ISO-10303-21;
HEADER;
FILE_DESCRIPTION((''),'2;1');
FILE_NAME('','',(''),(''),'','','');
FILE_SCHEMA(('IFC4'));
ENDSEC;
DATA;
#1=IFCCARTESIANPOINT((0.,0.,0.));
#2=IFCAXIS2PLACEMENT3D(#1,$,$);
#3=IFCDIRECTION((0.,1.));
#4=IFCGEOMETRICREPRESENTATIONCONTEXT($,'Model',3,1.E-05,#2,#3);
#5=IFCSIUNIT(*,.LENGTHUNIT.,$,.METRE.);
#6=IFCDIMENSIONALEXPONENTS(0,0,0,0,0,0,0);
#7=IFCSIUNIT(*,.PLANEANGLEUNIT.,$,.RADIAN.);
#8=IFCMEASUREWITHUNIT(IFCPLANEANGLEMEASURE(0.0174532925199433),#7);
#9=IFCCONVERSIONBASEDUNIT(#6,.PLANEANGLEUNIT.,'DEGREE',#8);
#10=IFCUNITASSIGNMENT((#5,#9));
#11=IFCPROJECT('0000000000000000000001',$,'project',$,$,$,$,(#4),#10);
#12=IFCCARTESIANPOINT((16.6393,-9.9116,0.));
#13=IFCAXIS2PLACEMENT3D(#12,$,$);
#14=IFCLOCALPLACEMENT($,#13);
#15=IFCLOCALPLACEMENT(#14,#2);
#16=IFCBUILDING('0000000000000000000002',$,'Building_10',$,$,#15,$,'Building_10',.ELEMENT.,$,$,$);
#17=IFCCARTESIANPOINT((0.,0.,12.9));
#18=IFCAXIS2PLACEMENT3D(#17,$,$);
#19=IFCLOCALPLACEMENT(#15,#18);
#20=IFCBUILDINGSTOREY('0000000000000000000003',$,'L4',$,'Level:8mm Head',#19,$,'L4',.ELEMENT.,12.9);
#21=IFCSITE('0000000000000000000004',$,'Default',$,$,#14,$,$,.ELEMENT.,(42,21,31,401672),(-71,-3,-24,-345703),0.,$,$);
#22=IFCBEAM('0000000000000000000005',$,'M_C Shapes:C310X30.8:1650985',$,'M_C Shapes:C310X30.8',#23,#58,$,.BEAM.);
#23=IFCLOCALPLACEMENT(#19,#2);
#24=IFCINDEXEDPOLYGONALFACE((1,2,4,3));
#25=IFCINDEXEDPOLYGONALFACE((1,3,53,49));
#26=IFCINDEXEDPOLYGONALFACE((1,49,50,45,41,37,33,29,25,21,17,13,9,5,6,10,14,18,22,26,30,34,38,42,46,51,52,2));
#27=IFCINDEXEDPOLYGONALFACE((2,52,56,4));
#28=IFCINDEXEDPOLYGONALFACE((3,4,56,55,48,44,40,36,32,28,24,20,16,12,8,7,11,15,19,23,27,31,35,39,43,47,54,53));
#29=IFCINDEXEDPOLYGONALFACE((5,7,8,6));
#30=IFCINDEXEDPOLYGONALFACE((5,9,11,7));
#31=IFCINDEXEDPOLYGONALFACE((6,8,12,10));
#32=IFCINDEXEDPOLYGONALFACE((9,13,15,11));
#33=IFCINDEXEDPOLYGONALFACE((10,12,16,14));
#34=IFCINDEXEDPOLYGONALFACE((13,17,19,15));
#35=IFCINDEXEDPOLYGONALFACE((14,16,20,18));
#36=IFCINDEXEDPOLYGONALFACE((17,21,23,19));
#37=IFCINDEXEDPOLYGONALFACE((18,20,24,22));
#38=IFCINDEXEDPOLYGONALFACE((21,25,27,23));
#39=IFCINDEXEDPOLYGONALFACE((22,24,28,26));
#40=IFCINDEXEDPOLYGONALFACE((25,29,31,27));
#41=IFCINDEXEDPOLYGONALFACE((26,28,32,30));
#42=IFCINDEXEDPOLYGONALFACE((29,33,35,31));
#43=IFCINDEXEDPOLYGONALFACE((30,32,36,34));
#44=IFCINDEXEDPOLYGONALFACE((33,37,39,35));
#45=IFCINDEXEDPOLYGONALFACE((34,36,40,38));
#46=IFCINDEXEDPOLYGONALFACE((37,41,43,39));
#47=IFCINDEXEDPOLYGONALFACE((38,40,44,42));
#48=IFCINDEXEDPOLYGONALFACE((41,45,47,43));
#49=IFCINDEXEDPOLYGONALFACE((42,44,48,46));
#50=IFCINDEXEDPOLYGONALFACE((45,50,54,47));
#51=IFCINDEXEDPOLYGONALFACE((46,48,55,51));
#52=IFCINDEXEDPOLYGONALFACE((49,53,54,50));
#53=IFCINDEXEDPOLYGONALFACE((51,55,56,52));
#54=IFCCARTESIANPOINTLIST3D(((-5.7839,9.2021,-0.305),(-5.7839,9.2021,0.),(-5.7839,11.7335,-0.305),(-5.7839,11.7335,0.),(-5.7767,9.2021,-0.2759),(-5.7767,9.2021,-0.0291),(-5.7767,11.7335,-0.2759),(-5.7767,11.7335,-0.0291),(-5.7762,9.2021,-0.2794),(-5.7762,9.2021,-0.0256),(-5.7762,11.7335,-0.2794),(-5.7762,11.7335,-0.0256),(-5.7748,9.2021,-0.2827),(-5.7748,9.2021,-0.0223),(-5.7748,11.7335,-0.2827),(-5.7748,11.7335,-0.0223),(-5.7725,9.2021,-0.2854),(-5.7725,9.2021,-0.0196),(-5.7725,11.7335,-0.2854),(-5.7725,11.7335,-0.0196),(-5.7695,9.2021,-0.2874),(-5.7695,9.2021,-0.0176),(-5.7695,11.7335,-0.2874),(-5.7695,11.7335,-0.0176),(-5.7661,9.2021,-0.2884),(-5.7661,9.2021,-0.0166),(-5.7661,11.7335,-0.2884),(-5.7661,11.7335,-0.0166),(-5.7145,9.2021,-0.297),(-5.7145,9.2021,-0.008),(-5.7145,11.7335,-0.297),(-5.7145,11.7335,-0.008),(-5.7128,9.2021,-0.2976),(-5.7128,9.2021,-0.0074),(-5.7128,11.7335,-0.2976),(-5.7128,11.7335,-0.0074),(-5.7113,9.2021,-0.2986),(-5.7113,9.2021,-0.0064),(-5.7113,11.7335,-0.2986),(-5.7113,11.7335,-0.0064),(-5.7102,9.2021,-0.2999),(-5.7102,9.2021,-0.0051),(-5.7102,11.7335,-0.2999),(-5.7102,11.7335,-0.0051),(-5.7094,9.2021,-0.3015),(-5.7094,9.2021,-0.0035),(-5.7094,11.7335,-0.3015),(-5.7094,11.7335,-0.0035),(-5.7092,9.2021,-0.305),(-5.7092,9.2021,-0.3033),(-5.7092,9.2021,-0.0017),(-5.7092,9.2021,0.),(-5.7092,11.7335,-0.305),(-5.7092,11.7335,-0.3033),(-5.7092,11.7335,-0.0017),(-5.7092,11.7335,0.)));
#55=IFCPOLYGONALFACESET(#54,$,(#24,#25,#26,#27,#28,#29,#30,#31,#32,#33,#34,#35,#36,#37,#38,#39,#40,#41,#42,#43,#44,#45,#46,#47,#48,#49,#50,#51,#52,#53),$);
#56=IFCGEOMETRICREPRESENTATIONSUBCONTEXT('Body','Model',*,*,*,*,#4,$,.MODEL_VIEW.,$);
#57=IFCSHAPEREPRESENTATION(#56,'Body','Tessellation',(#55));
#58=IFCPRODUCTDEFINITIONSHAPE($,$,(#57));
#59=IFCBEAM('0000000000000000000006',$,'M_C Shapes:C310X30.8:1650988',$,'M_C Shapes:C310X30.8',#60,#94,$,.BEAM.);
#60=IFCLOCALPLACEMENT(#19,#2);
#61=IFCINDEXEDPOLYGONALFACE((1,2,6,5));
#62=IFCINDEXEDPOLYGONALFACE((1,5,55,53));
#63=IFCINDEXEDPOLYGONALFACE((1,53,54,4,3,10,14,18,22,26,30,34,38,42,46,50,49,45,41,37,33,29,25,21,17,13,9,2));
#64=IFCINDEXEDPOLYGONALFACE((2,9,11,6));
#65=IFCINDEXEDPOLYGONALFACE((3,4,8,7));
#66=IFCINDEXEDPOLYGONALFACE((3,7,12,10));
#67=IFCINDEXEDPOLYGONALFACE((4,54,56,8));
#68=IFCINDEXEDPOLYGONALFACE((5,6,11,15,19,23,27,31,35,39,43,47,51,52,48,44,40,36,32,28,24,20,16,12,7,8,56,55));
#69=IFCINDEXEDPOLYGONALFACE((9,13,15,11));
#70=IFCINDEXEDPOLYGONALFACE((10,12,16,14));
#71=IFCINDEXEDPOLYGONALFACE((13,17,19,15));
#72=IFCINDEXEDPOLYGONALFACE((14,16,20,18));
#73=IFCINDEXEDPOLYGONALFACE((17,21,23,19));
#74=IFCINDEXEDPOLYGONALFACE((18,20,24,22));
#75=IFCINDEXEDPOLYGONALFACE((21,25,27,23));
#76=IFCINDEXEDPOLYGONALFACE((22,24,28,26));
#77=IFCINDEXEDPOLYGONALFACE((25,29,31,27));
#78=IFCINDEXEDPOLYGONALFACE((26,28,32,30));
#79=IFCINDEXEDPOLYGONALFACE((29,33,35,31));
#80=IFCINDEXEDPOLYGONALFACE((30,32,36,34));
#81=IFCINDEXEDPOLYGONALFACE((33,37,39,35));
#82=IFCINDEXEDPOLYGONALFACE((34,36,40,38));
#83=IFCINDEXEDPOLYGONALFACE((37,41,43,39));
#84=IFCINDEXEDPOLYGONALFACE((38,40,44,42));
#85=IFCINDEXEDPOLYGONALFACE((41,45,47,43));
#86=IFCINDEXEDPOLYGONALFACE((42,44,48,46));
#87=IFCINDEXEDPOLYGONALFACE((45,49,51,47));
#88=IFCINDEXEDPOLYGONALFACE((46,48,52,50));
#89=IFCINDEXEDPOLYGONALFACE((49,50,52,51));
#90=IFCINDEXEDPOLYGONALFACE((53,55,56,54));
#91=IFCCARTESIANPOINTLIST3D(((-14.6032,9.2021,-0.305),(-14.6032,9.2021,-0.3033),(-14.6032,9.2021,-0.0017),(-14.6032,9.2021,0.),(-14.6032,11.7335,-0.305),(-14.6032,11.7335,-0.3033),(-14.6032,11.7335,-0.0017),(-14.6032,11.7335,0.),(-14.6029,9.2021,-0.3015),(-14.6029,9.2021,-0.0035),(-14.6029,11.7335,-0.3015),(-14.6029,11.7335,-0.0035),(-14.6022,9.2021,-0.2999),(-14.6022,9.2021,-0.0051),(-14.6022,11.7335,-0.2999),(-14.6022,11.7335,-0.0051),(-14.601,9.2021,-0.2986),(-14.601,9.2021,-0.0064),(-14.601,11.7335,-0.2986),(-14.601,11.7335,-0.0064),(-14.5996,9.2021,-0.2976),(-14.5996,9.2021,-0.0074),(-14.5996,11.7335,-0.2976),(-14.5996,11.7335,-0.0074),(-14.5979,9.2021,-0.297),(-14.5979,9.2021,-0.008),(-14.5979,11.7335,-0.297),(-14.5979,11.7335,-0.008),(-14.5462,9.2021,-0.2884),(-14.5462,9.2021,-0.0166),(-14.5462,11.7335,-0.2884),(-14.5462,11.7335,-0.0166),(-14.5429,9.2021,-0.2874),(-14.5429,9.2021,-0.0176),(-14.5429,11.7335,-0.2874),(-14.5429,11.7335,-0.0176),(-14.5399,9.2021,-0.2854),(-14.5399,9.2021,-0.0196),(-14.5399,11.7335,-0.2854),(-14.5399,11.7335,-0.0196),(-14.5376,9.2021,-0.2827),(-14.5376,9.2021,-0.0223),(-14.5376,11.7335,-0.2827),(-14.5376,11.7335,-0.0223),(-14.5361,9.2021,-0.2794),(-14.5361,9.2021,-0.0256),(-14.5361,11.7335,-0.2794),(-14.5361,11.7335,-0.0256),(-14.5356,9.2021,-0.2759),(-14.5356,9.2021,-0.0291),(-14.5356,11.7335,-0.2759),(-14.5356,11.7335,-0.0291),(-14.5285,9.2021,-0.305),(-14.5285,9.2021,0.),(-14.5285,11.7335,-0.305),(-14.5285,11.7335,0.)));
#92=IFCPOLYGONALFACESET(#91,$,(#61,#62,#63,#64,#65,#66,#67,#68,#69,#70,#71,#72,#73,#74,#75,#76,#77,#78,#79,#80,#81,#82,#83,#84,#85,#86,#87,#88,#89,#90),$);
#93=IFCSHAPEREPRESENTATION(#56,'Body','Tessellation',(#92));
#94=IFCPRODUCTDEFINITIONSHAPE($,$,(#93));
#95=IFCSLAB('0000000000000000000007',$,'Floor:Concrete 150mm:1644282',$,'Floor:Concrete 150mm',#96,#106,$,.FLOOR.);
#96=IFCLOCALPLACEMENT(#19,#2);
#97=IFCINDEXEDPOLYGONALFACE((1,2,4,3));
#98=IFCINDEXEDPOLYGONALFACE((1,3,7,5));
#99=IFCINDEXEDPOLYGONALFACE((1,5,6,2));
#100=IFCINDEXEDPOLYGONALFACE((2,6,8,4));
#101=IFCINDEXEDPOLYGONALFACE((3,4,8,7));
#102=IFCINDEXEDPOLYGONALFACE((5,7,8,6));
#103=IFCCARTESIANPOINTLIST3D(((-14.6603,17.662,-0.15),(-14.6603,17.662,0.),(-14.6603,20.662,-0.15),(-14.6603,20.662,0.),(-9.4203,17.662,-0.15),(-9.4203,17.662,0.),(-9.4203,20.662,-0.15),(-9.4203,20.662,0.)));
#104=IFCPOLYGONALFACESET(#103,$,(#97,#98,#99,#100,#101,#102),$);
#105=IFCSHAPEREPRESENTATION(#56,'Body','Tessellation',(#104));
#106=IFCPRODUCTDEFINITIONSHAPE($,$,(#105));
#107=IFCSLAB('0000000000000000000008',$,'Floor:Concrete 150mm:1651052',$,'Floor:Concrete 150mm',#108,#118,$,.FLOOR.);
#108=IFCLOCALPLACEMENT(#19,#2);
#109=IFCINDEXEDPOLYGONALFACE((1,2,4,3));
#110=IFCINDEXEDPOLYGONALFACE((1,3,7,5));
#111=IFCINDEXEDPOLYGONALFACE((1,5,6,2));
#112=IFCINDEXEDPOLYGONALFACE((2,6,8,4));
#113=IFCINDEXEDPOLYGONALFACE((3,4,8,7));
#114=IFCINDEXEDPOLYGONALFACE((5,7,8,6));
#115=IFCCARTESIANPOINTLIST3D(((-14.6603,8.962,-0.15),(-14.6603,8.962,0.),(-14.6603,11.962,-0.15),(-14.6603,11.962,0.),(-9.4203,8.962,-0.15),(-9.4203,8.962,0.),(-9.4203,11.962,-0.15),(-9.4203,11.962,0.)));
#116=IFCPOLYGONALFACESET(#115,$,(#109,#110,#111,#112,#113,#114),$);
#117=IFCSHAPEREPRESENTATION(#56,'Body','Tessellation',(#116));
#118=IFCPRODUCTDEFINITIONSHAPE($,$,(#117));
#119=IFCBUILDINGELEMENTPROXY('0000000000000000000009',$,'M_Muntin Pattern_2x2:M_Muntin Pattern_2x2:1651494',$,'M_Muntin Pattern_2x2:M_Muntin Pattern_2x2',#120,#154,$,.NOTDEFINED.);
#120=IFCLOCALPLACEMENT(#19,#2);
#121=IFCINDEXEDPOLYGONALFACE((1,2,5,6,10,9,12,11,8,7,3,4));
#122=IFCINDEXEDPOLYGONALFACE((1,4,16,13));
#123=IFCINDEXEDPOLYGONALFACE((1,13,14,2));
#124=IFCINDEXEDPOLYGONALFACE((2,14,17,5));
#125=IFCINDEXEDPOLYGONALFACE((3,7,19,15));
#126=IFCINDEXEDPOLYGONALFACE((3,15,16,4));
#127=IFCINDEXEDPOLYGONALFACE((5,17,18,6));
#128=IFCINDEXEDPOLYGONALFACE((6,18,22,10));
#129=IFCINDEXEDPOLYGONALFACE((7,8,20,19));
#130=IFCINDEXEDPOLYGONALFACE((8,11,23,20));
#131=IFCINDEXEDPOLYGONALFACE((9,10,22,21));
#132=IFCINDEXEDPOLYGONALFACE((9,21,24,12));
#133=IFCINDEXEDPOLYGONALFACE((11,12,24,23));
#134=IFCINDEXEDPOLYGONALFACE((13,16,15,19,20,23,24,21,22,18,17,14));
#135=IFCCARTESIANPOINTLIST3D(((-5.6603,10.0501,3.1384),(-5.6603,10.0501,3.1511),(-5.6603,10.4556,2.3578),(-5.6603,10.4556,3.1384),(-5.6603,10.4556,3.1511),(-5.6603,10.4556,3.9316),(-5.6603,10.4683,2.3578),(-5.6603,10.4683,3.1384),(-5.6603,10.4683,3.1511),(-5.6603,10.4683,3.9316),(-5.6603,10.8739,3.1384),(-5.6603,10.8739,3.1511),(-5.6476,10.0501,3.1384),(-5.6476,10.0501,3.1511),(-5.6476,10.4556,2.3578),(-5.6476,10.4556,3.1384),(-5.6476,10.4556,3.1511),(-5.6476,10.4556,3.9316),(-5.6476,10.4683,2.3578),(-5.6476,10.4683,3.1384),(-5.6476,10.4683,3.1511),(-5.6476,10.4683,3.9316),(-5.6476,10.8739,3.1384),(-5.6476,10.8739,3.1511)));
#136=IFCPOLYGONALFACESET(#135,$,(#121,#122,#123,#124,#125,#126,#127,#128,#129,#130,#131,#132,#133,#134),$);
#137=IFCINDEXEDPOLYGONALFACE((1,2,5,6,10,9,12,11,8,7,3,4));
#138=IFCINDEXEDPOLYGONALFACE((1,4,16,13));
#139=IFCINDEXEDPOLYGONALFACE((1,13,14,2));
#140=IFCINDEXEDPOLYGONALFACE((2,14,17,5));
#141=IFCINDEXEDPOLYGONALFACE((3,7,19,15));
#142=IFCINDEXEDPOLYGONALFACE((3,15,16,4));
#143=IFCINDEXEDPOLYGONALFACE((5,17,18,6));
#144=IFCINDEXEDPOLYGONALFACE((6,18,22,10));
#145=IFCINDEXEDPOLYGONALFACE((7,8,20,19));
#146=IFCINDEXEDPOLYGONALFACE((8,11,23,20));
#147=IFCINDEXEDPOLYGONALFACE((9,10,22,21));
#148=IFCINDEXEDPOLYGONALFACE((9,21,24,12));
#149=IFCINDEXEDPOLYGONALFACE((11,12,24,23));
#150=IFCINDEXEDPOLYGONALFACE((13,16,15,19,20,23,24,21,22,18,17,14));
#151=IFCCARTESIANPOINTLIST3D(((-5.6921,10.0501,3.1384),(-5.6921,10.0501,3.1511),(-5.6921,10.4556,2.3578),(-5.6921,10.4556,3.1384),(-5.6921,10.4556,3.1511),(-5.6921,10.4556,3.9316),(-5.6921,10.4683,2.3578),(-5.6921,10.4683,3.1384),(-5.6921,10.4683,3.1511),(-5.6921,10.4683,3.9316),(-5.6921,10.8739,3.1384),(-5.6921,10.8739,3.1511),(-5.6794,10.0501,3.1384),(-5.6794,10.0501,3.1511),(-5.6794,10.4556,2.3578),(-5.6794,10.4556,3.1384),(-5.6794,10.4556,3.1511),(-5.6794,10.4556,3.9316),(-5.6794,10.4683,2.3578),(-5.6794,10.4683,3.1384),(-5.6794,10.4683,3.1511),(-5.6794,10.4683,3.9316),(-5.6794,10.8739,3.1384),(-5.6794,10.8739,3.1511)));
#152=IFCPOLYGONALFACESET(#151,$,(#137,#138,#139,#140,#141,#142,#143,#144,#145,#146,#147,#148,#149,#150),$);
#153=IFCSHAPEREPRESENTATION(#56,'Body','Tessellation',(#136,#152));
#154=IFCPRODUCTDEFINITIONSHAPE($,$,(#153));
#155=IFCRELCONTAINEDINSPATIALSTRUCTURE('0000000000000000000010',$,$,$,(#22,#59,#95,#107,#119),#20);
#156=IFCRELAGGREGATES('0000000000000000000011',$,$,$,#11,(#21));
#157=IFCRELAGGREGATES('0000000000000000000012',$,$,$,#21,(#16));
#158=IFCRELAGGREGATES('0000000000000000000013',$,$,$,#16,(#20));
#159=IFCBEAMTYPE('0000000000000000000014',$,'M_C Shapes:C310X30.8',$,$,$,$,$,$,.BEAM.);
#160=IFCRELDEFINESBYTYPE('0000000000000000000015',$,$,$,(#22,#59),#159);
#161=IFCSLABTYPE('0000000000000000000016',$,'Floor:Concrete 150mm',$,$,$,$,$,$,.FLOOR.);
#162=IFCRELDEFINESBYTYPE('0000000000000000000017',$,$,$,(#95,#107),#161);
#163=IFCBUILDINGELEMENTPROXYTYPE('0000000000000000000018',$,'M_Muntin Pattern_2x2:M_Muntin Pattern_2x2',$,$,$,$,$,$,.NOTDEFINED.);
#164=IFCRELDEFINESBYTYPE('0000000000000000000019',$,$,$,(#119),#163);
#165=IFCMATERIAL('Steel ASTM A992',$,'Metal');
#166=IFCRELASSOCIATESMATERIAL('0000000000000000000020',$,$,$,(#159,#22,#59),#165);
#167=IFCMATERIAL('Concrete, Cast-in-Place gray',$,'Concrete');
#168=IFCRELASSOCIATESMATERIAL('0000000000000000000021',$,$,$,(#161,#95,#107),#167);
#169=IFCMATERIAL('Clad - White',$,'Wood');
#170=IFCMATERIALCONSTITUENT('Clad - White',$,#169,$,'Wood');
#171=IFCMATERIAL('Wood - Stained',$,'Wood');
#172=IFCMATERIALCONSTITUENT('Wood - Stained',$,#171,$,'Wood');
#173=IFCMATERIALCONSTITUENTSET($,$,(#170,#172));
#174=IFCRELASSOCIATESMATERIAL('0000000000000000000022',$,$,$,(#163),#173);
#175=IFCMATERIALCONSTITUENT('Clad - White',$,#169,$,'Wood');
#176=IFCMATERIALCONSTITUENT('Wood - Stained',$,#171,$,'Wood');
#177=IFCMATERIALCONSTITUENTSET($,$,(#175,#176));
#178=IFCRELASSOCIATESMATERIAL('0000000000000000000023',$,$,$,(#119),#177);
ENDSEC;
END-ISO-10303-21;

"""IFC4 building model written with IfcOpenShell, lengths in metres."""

from ifc_helpers import new_model, entity, si_unit, converted_unit, direction, frame, origin, place, context, subcontext, project, spatial, line, arc, indexed_curve, outline, extrude, source, transform, mapped, material, constituent, constituent_set, type_object, type_shapes, element, save


model = new_model("IFC4")

# Units and contexts
model_context = context("Model", 3, precision=1e-05, world=origin(), true_north=direction((0.0, 1.0)))
body_context = subcontext(model_context, "Body", "Model", "MODEL_VIEW")
ifc_project = project(units=[si_unit("LENGTHUNIT", "METRE"), converted_unit("PLANEANGLEUNIT", "DEGREE", entity("IfcPlaneAngleMeasure", 0.0174532925199433), si_unit("PLANEANGLEUNIT", "RADIAN"), dimensions=[0, 0, 0, 0, 0, 0, 0])], contexts=[model_context])

# Site, building, storey
site_placement = place(None, frame((16.6393, -9.9116, 0.0)))
site = spatial("IfcSite", under=ifc_project, at=site_placement, Name="Default", CompositionType="ELEMENT", RefLatitude=(42, 21, 31, 401672), RefLongitude=(-71, -3, -24, -345703), RefElevation=0.0)
building_placement = place(site_placement, origin())
building = spatial("IfcBuilding", under=site, at=building_placement, Name="Building_10", LongName="Building_10", CompositionType="ELEMENT")
storey_placement = place(building_placement, frame((0.0, 0.0, 12.9)))
storey = spatial("IfcBuildingStorey", under=building, at=storey_placement, Name="L4", ObjectType="Level:8mm Head", LongName="L4", CompositionType="ELEMENT", Elevation=12.9)

# Shared definitions
ifc_material_1 = material(Name="Steel ASTM A992", Category="Metal")

# Beams
beam_type_1 = type_object("IfcBeamType", Name="M_C Shapes:C310X30.8", PredefinedType="BEAM", material=ifc_material_1)
shared_shape_1 = source(origin(), body_context, "Body", "SweptSolid", [
    extrude(outline(indexed_curve([(-0.0406, -0.1525), (0.0341, -0.1525), (0.0341, -0.1508), (0.0326, -0.1467), (0.0288, -0.1445), (-0.0228, -0.1359), (-0.0305, -0.1316), (-0.0335, -0.1234), (-0.0335, 0.1234), (-0.0305, 0.1316), (-0.0228, 0.1359), (0.0288, 0.1445), (0.0326, 0.1467), (0.0341, 0.1508), (0.0341, 0.1525), (-0.0406, 0.1525)], segments=[line(1, 2, 3), arc(3, 4, 5), line(5, 6), arc(6, 7, 8), line(8, 9), arc(9, 10, 11), line(11, 12), arc(12, 13, 14), line(14, 15, 16, 1)], self_intersect=False)), frame((-1.2657, -0.0229, 0.0), z_axis=(1.0, 0.0, 0.0), x_axis=(0.0, -1.0, 0.0)), (0.0, 0.0, 1.0), 2.5314),
])
type_shapes(beam_type_1, [shared_shape_1])
for number, where, z_axis, x_axis, name in (
    (1, (-5.7662, 10.4678, -0.1525), (0.0, 0.0, 1.0), (0.0, 1.0, 0.0), "M_C Shapes:C310X30.8:1650985"),
    (2, (-14.5462, 10.4678, -0.1525), (0.0, 0.0, 1.0), (0.0, -1.0, 0.0), "M_C Shapes:C310X30.8:1650988"),
):
    element("IfcBeam", number, at=place(storey_placement, frame(where, z_axis=z_axis, x_axis=x_axis)), inside=storey, type_object=beam_type_1, material=ifc_material_1, Name=name, ObjectType="M_C Shapes:C310X30.8", PredefinedType="BEAM", context=body_context, shape_type="MappedRepresentation", body=[
        mapped(shared_shape_1, transform((0.0, 0.0, 0.0), scale=1.0)),
    ])

# Slabs
ifc_material_2 = material(Name="Concrete, Cast-in-Place gray", Category="Concrete")
slab_type = type_object("IfcSlabType", Name="Floor:Concrete 150mm", PredefinedType="FLOOR", material=ifc_material_2)
slab_1_placement = place(storey_placement, origin())
element("IfcSlab", 3, at=slab_1_placement, inside=storey, type_object=slab_type, material=ifc_material_2, Name="Floor:Concrete 150mm:1644282", ObjectType="Floor:Concrete 150mm", PredefinedType="FLOOR", context=body_context, shape_type="SweptSolid", body=[
    extrude(outline(indexed_curve([(-1.5, -2.62), (1.5, -2.62), (1.5, 2.62), (-1.5, 2.62), (-1.5, -2.62)], self_intersect=False)), frame((-12.0403, 19.162, 0.0), z_axis=(0.0, 0.0, -1.0), x_axis=(0.0, 1.0, 0.0)), (0.0, 0.0, 1.0), 0.15),
])
slab_2_placement = place(storey_placement, origin())
element("IfcSlab", 4, at=slab_2_placement, inside=storey, type_object=slab_type, material=ifc_material_2, Name="Floor:Concrete 150mm:1651052", ObjectType="Floor:Concrete 150mm", PredefinedType="FLOOR", context=body_context, shape_type="SweptSolid", body=[
    extrude(outline(indexed_curve([(-1.5, -2.62), (1.5, -2.62), (1.5, 2.62), (-1.5, 2.62), (-1.5, -2.62)], self_intersect=False)), frame((-12.0403, 10.462, 0.0), z_axis=(0.0, 0.0, -1.0), x_axis=(0.0, 1.0, 0.0)), (0.0, 0.0, 1.0), 0.15),
])

# Building element proxy
ifc_material_3 = material(Name="Clad - White", Category="Wood")
ifc_constituent_1 = constituent(ifc_material_3, Name="Clad - White", Category="Wood")
ifc_material_4 = material(Name="Wood - Stained", Category="Wood")
ifc_constituent_2 = constituent(ifc_material_4, Name="Wood - Stained", Category="Wood")
ifc_constituent_set_1 = constituent_set(constituents=[ifc_constituent_1, ifc_constituent_2])
ifc_constituent_3 = constituent(ifc_material_3, Name="Clad - White", Category="Wood")
ifc_constituent_4 = constituent(ifc_material_4, Name="Wood - Stained", Category="Wood")
ifc_constituent_set_2 = constituent_set(constituents=[ifc_constituent_3, ifc_constituent_4])
building_element_proxy_type_1 = type_object("IfcBuildingElementProxyType", Name="M_Muntin Pattern_2x2:M_Muntin Pattern_2x2", PredefinedType="NOTDEFINED", material=ifc_constituent_set_2)
shared_shape_2 = source(origin(), body_context, "Body", "SweptSolid", [
    extrude(outline(indexed_curve([(0.0064, -0.0064), (0.7869, -0.0064), (0.7869, 0.0063), (0.0064, 0.0063), (0.0064, 0.4119), (-0.0063, 0.4119), (-0.0063, 0.0063), (-0.7869, 0.0063), (-0.7869, -0.0064), (-0.0063, -0.0064), (-0.0063, -0.4119), (0.0064, -0.4119), (0.0064, -0.0064)], self_intersect=False)), frame((0.0, -0.0222, 0.7869), z_axis=(0.0, 1.0, 0.0), x_axis=(0.0, 0.0, 1.0)), (0.0, 0.0, 1.0), 0.0127),
    extrude(outline(indexed_curve([(0.0064, -0.0064), (0.7869, -0.0064), (0.7869, 0.0063), (0.0064, 0.0063), (0.0064, 0.4119), (-0.0063, 0.4119), (-0.0063, 0.0063), (-0.7869, 0.0063), (-0.7869, -0.0064), (-0.0063, -0.0064), (-0.0063, -0.4119), (0.0064, -0.4119), (0.0064, -0.0064)], self_intersect=False)), frame((0.0, 0.0095, 0.7869), z_axis=(0.0, 1.0, 0.0), x_axis=(0.0, 0.0, 1.0)), (0.0, 0.0, 1.0), 0.0127),
])
type_shapes(building_element_proxy_type_1, [shared_shape_2])
proxy_1_placement = place(storey_placement, frame((-5.6698, 10.462, 2.3578), z_axis=(0.0, 0.0, 1.0), x_axis=(0.0, 1.0, 0.0)))
element("IfcBuildingElementProxy", 5, at=proxy_1_placement, inside=storey, type_object=building_element_proxy_type_1, material=ifc_constituent_set_1, Name="M_Muntin Pattern_2x2:M_Muntin Pattern_2x2:1651494", ObjectType="M_Muntin Pattern_2x2:M_Muntin Pattern_2x2", PredefinedType="NOTDEFINED", context=body_context, shape_type="MappedRepresentation", body=[
    mapped(shared_shape_2, transform((0.0, 0.0, 0.0), scale=1.0)),
])

save(model, "model.ifc")
